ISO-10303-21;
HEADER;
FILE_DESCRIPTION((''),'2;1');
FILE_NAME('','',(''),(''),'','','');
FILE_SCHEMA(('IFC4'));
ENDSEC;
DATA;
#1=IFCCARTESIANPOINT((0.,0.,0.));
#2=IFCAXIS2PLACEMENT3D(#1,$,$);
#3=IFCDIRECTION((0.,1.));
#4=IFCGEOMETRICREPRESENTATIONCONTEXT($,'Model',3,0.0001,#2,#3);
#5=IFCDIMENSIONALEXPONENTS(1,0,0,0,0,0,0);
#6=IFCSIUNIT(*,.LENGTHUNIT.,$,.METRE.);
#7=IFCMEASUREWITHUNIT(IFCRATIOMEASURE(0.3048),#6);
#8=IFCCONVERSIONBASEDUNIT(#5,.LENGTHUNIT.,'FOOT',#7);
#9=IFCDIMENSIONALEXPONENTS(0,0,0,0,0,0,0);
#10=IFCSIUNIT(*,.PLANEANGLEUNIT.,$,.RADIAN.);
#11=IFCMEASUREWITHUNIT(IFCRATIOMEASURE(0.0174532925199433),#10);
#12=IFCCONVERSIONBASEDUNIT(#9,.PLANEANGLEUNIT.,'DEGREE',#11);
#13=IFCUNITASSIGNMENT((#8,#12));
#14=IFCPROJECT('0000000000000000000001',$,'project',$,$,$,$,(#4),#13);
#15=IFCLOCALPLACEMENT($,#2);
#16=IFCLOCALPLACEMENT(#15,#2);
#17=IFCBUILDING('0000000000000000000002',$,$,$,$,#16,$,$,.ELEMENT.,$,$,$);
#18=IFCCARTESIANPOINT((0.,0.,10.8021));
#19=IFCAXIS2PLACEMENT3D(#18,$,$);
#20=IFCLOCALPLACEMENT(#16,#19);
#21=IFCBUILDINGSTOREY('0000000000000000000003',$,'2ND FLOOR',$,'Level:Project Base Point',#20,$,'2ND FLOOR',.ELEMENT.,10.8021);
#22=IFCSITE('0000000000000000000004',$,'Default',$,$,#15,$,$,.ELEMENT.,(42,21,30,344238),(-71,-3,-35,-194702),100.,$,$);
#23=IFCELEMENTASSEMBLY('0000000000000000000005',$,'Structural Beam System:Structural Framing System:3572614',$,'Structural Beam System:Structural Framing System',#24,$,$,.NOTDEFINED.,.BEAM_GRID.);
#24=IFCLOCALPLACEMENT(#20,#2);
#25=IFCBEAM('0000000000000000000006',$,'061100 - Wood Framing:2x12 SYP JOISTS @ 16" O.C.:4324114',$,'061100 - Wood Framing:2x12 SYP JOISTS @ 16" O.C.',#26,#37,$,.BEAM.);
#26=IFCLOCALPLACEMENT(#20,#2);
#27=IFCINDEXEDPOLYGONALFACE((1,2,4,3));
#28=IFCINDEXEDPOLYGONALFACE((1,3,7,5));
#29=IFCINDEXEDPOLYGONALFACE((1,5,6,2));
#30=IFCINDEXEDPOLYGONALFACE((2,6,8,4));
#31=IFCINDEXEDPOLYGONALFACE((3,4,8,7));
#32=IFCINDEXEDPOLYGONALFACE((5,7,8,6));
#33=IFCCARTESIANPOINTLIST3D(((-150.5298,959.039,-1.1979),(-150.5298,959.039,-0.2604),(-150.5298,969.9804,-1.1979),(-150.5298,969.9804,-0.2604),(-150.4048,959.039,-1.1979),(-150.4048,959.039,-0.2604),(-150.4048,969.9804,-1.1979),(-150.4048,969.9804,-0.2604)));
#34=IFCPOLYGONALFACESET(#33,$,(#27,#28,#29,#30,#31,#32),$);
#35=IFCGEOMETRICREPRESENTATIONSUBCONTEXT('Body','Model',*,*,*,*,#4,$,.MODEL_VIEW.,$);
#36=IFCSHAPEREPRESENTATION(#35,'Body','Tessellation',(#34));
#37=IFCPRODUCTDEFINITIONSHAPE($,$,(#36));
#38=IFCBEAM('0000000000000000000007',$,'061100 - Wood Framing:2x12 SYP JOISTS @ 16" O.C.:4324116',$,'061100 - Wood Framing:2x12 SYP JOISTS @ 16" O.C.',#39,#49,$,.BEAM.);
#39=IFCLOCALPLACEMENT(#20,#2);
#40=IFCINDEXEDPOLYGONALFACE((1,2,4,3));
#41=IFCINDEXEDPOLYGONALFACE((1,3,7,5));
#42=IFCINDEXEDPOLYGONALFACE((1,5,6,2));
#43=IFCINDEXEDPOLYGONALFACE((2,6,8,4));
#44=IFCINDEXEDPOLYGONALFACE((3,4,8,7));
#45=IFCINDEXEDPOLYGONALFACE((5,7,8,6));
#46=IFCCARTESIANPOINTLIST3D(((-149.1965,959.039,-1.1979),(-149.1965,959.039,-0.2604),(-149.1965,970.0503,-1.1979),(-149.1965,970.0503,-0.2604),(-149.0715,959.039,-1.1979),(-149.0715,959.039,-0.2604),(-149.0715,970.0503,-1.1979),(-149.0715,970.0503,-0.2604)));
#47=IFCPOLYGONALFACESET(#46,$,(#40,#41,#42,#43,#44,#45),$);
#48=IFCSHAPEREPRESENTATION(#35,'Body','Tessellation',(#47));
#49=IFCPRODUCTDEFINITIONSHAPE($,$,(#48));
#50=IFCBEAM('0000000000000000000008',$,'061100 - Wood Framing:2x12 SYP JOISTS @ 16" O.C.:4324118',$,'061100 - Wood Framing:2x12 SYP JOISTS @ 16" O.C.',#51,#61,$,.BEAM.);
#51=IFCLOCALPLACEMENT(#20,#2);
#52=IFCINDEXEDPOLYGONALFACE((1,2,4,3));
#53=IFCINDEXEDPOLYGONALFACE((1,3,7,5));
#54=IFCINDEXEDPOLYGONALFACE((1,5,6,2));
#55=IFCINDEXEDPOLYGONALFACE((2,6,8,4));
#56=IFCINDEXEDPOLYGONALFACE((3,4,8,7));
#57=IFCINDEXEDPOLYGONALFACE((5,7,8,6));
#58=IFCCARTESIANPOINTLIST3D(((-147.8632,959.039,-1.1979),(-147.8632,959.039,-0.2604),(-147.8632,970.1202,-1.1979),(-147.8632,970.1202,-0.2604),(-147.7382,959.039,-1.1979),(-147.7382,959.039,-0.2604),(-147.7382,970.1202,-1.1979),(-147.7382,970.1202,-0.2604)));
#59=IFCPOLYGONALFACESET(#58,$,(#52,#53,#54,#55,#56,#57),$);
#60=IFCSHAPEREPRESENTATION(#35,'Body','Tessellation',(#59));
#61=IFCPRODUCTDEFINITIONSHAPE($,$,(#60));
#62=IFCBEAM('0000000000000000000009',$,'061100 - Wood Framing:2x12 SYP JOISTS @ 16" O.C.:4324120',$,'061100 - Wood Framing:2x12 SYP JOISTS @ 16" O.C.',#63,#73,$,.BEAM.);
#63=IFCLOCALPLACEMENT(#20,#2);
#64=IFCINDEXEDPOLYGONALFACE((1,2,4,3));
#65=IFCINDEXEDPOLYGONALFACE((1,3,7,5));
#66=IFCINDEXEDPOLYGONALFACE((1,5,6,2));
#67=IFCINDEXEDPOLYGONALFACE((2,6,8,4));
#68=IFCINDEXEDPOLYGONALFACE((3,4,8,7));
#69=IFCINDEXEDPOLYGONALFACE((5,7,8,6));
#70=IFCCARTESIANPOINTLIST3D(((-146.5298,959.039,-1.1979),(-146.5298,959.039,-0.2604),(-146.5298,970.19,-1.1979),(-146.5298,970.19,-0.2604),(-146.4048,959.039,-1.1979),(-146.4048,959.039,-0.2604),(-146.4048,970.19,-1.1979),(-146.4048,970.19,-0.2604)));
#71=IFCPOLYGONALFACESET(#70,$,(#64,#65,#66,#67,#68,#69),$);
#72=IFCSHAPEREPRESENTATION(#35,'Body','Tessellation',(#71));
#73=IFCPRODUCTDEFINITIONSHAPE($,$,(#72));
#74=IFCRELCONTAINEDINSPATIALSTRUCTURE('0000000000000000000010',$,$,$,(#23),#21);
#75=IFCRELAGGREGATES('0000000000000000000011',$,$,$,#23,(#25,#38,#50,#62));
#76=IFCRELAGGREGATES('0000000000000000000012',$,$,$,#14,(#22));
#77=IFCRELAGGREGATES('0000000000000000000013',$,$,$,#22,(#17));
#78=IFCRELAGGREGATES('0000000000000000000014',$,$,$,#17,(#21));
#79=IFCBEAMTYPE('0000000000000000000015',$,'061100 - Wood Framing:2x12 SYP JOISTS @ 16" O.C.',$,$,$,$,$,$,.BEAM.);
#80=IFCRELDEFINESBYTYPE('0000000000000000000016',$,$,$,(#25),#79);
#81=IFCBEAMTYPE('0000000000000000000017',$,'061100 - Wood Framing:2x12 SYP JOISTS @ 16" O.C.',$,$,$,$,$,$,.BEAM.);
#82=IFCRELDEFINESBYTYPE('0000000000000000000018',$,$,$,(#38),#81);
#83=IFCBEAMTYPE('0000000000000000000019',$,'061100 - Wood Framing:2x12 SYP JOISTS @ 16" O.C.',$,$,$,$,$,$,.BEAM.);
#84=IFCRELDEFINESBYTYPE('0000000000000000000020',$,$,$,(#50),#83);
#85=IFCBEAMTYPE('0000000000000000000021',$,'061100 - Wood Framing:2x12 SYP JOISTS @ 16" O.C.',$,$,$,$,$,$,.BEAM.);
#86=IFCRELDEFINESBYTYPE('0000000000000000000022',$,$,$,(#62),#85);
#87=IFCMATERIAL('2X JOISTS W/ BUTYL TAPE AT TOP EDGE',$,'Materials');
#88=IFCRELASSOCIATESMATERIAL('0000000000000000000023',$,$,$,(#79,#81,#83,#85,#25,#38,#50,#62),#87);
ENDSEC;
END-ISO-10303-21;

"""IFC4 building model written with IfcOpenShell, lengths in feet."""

from ifc_helpers import new_model, entity, si_unit, converted_unit, direction, frame, origin, origin_2d_with_axis, place, context, subcontext, project, spatial, rectangle, extrude, source, transform, mapped, material, material_profile, profile_set, profile_usage, type_object, type_shapes, element, aggregate, save


model = new_model("IFC4")

# Units and contexts
model_context = context("Model", 3, precision=0.0001, world=origin(), true_north=direction((0.0, 1.0)))
body_context = subcontext(model_context, "Body", "Model", "MODEL_VIEW")
ifc_project = project(units=[converted_unit("LENGTHUNIT", "FOOT", entity("IfcRatioMeasure", 0.3048), si_unit("LENGTHUNIT", "METRE"), dimensions=[1, 0, 0, 0, 0, 0, 0]), converted_unit("PLANEANGLEUNIT", "DEGREE", entity("IfcRatioMeasure", 0.0174532925199433), si_unit("PLANEANGLEUNIT", "RADIAN"), dimensions=[0, 0, 0, 0, 0, 0, 0])], contexts=[model_context])

# Site, building, storey
site_placement = place(None, origin())
site = spatial("IfcSite", under=ifc_project, at=site_placement, Name="Default", CompositionType="ELEMENT", RefLatitude=(42, 21, 30, 344238), RefLongitude=(-71, -3, -35, -194702), RefElevation=100.0)
building_placement = place(site_placement, origin())
building = spatial("IfcBuilding", under=site, at=building_placement, CompositionType="ELEMENT")
storey_placement = place(building_placement, frame((0.0, 0.0, 10.8021)))
storey = spatial("IfcBuildingStorey", under=building, at=storey_placement, Name="2ND FLOOR", ObjectType="Level:Project Base Point", LongName="2ND FLOOR", CompositionType="ELEMENT", Elevation=10.8021)

# Element assembly, beams
assembly_placement = place(storey_placement, origin())
assembly = element("IfcElementAssembly", 1, at=assembly_placement, inside=storey, Name="Structural Beam System:Structural Framing System:3572614", ObjectType="Structural Beam System:Structural Framing System", AssemblyPlace="NOTDEFINED", PredefinedType="BEAM_GRID")
ifc_material_1 = material(Name="2X JOISTS W/ BUTYL TAPE AT TOP EDGE", Category="Materials")
ifc_material_profile = material_profile(ifc_material_1, rectangle(XDim=0.9375, YDim=0.125, at=origin_2d_with_axis()), Name="2x12 SYP JOISTS @ 16\" O.C.")
ifc_profile_set = profile_set([ifc_material_profile], Name="2x12 SYP JOISTS @ 16\" O.C.")
ifc_profile_usage_1 = profile_usage(ifc_profile_set, cardinal=8)
beam_type_1 = type_object("IfcBeamType", Name="061100 - Wood Framing:2x12 SYP JOISTS @ 16\" O.C.", PredefinedType="BEAM", material=ifc_profile_set)
shared_shape_1 = source(origin(), body_context, "Body", "SweptSolid", [
    extrude(rectangle(XDim=0.9375, YDim=0.125, at=origin_2d_with_axis()), frame((-5.4707, 0.0, 0.0), z_axis=(1.0, 0.0, 0.0), x_axis=(0.0, 0.0, -1.0)), (0.0, 0.0, 1.0), 10.9414),
])
type_shapes(beam_type_1, [shared_shape_1])
beam_1_placement = place(assembly_placement, frame((-150.4673, 964.5097, -0.7292), z_axis=(0.0, 0.0, 1.0), x_axis=(0.0, 1.0, 0.0)))
beam_1 = element("IfcBeam", 2, at=beam_1_placement, type_object=beam_type_1, material=ifc_profile_usage_1, Name="061100 - Wood Framing:2x12 SYP JOISTS @ 16\" O.C.:4324114", ObjectType="061100 - Wood Framing:2x12 SYP JOISTS @ 16\" O.C.", PredefinedType="BEAM", context=body_context, shape_type="MappedRepresentation", body=[
    mapped(shared_shape_1, transform((0.0, 0.0, 0.0), scale=1.0)),
])
ifc_profile_usage_2 = profile_usage(ifc_profile_set, cardinal=8)
beam_type_2 = type_object("IfcBeamType", Name="061100 - Wood Framing:2x12 SYP JOISTS @ 16\" O.C.", PredefinedType="BEAM", material=ifc_profile_set)
shared_shape_2 = source(origin(), body_context, "Body", "SweptSolid", [
    extrude(rectangle(XDim=0.9375, YDim=0.125, at=origin_2d_with_axis()), frame((-5.5056, 0.0, 0.0), z_axis=(1.0, 0.0, 0.0), x_axis=(0.0, 0.0, -1.0)), (0.0, 0.0, 1.0), 11.0113),
])
type_shapes(beam_type_2, [shared_shape_2])
beam_2_placement = place(assembly_placement, frame((-149.134, 964.5447, -0.7292), z_axis=(0.0, 0.0, 1.0), x_axis=(0.0, 1.0, 0.0)))
beam_2 = element("IfcBeam", 3, at=beam_2_placement, type_object=beam_type_2, material=ifc_profile_usage_2, Name="061100 - Wood Framing:2x12 SYP JOISTS @ 16\" O.C.:4324116", ObjectType="061100 - Wood Framing:2x12 SYP JOISTS @ 16\" O.C.", PredefinedType="BEAM", context=body_context, shape_type="MappedRepresentation", body=[
    mapped(shared_shape_2, transform((0.0, 0.0, 0.0), scale=1.0)),
])
ifc_profile_usage_3 = profile_usage(ifc_profile_set, cardinal=8)
beam_type_3 = type_object("IfcBeamType", Name="061100 - Wood Framing:2x12 SYP JOISTS @ 16\" O.C.", PredefinedType="BEAM", material=ifc_profile_set)
shared_shape_3 = source(origin(), body_context, "Body", "SweptSolid", [
    extrude(rectangle(XDim=0.9375, YDim=0.125, at=origin_2d_with_axis()), frame((-5.5406, 0.0, 0.0), z_axis=(1.0, 0.0, 0.0), x_axis=(0.0, 0.0, -1.0)), (0.0, 0.0, 1.0), 11.0811),
])
type_shapes(beam_type_3, [shared_shape_3])
beam_3_placement = place(assembly_placement, frame((-147.8007, 964.5796, -0.7292), z_axis=(0.0, 0.0, 1.0), x_axis=(0.0, 1.0, 0.0)))
beam_3 = element("IfcBeam", 4, at=beam_3_placement, type_object=beam_type_3, material=ifc_profile_usage_3, Name="061100 - Wood Framing:2x12 SYP JOISTS @ 16\" O.C.:4324118", ObjectType="061100 - Wood Framing:2x12 SYP JOISTS @ 16\" O.C.", PredefinedType="BEAM", context=body_context, shape_type="MappedRepresentation", body=[
    mapped(shared_shape_3, transform((0.0, 0.0, 0.0), scale=1.0)),
])
ifc_profile_usage_4 = profile_usage(ifc_profile_set, cardinal=8)
beam_type_4 = type_object("IfcBeamType", Name="061100 - Wood Framing:2x12 SYP JOISTS @ 16\" O.C.", PredefinedType="BEAM", material=ifc_profile_set)
shared_shape_4 = source(origin(), body_context, "Body", "SweptSolid", [
    extrude(rectangle(XDim=0.9375, YDim=0.125, at=origin_2d_with_axis()), frame((-5.5755, 0.0, 0.0), z_axis=(1.0, 0.0, 0.0), x_axis=(0.0, 0.0, -1.0)), (0.0, 0.0, 1.0), 11.151),
])
type_shapes(beam_type_4, [shared_shape_4])
beam_4_placement = place(assembly_placement, frame((-146.4673, 964.6145, -0.7292), z_axis=(0.0, 0.0, 1.0), x_axis=(0.0, 1.0, 0.0)))
beam_4 = element("IfcBeam", 5, at=beam_4_placement, type_object=beam_type_4, material=ifc_profile_usage_4, Name="061100 - Wood Framing:2x12 SYP JOISTS @ 16\" O.C.:4324120", ObjectType="061100 - Wood Framing:2x12 SYP JOISTS @ 16\" O.C.", PredefinedType="BEAM", context=body_context, shape_type="MappedRepresentation", body=[
    mapped(shared_shape_4, transform((0.0, 0.0, 0.0), scale=1.0)),
])
aggregate(assembly, [beam_1, beam_2, beam_3, beam_4])

save(model, "model.ifc")
